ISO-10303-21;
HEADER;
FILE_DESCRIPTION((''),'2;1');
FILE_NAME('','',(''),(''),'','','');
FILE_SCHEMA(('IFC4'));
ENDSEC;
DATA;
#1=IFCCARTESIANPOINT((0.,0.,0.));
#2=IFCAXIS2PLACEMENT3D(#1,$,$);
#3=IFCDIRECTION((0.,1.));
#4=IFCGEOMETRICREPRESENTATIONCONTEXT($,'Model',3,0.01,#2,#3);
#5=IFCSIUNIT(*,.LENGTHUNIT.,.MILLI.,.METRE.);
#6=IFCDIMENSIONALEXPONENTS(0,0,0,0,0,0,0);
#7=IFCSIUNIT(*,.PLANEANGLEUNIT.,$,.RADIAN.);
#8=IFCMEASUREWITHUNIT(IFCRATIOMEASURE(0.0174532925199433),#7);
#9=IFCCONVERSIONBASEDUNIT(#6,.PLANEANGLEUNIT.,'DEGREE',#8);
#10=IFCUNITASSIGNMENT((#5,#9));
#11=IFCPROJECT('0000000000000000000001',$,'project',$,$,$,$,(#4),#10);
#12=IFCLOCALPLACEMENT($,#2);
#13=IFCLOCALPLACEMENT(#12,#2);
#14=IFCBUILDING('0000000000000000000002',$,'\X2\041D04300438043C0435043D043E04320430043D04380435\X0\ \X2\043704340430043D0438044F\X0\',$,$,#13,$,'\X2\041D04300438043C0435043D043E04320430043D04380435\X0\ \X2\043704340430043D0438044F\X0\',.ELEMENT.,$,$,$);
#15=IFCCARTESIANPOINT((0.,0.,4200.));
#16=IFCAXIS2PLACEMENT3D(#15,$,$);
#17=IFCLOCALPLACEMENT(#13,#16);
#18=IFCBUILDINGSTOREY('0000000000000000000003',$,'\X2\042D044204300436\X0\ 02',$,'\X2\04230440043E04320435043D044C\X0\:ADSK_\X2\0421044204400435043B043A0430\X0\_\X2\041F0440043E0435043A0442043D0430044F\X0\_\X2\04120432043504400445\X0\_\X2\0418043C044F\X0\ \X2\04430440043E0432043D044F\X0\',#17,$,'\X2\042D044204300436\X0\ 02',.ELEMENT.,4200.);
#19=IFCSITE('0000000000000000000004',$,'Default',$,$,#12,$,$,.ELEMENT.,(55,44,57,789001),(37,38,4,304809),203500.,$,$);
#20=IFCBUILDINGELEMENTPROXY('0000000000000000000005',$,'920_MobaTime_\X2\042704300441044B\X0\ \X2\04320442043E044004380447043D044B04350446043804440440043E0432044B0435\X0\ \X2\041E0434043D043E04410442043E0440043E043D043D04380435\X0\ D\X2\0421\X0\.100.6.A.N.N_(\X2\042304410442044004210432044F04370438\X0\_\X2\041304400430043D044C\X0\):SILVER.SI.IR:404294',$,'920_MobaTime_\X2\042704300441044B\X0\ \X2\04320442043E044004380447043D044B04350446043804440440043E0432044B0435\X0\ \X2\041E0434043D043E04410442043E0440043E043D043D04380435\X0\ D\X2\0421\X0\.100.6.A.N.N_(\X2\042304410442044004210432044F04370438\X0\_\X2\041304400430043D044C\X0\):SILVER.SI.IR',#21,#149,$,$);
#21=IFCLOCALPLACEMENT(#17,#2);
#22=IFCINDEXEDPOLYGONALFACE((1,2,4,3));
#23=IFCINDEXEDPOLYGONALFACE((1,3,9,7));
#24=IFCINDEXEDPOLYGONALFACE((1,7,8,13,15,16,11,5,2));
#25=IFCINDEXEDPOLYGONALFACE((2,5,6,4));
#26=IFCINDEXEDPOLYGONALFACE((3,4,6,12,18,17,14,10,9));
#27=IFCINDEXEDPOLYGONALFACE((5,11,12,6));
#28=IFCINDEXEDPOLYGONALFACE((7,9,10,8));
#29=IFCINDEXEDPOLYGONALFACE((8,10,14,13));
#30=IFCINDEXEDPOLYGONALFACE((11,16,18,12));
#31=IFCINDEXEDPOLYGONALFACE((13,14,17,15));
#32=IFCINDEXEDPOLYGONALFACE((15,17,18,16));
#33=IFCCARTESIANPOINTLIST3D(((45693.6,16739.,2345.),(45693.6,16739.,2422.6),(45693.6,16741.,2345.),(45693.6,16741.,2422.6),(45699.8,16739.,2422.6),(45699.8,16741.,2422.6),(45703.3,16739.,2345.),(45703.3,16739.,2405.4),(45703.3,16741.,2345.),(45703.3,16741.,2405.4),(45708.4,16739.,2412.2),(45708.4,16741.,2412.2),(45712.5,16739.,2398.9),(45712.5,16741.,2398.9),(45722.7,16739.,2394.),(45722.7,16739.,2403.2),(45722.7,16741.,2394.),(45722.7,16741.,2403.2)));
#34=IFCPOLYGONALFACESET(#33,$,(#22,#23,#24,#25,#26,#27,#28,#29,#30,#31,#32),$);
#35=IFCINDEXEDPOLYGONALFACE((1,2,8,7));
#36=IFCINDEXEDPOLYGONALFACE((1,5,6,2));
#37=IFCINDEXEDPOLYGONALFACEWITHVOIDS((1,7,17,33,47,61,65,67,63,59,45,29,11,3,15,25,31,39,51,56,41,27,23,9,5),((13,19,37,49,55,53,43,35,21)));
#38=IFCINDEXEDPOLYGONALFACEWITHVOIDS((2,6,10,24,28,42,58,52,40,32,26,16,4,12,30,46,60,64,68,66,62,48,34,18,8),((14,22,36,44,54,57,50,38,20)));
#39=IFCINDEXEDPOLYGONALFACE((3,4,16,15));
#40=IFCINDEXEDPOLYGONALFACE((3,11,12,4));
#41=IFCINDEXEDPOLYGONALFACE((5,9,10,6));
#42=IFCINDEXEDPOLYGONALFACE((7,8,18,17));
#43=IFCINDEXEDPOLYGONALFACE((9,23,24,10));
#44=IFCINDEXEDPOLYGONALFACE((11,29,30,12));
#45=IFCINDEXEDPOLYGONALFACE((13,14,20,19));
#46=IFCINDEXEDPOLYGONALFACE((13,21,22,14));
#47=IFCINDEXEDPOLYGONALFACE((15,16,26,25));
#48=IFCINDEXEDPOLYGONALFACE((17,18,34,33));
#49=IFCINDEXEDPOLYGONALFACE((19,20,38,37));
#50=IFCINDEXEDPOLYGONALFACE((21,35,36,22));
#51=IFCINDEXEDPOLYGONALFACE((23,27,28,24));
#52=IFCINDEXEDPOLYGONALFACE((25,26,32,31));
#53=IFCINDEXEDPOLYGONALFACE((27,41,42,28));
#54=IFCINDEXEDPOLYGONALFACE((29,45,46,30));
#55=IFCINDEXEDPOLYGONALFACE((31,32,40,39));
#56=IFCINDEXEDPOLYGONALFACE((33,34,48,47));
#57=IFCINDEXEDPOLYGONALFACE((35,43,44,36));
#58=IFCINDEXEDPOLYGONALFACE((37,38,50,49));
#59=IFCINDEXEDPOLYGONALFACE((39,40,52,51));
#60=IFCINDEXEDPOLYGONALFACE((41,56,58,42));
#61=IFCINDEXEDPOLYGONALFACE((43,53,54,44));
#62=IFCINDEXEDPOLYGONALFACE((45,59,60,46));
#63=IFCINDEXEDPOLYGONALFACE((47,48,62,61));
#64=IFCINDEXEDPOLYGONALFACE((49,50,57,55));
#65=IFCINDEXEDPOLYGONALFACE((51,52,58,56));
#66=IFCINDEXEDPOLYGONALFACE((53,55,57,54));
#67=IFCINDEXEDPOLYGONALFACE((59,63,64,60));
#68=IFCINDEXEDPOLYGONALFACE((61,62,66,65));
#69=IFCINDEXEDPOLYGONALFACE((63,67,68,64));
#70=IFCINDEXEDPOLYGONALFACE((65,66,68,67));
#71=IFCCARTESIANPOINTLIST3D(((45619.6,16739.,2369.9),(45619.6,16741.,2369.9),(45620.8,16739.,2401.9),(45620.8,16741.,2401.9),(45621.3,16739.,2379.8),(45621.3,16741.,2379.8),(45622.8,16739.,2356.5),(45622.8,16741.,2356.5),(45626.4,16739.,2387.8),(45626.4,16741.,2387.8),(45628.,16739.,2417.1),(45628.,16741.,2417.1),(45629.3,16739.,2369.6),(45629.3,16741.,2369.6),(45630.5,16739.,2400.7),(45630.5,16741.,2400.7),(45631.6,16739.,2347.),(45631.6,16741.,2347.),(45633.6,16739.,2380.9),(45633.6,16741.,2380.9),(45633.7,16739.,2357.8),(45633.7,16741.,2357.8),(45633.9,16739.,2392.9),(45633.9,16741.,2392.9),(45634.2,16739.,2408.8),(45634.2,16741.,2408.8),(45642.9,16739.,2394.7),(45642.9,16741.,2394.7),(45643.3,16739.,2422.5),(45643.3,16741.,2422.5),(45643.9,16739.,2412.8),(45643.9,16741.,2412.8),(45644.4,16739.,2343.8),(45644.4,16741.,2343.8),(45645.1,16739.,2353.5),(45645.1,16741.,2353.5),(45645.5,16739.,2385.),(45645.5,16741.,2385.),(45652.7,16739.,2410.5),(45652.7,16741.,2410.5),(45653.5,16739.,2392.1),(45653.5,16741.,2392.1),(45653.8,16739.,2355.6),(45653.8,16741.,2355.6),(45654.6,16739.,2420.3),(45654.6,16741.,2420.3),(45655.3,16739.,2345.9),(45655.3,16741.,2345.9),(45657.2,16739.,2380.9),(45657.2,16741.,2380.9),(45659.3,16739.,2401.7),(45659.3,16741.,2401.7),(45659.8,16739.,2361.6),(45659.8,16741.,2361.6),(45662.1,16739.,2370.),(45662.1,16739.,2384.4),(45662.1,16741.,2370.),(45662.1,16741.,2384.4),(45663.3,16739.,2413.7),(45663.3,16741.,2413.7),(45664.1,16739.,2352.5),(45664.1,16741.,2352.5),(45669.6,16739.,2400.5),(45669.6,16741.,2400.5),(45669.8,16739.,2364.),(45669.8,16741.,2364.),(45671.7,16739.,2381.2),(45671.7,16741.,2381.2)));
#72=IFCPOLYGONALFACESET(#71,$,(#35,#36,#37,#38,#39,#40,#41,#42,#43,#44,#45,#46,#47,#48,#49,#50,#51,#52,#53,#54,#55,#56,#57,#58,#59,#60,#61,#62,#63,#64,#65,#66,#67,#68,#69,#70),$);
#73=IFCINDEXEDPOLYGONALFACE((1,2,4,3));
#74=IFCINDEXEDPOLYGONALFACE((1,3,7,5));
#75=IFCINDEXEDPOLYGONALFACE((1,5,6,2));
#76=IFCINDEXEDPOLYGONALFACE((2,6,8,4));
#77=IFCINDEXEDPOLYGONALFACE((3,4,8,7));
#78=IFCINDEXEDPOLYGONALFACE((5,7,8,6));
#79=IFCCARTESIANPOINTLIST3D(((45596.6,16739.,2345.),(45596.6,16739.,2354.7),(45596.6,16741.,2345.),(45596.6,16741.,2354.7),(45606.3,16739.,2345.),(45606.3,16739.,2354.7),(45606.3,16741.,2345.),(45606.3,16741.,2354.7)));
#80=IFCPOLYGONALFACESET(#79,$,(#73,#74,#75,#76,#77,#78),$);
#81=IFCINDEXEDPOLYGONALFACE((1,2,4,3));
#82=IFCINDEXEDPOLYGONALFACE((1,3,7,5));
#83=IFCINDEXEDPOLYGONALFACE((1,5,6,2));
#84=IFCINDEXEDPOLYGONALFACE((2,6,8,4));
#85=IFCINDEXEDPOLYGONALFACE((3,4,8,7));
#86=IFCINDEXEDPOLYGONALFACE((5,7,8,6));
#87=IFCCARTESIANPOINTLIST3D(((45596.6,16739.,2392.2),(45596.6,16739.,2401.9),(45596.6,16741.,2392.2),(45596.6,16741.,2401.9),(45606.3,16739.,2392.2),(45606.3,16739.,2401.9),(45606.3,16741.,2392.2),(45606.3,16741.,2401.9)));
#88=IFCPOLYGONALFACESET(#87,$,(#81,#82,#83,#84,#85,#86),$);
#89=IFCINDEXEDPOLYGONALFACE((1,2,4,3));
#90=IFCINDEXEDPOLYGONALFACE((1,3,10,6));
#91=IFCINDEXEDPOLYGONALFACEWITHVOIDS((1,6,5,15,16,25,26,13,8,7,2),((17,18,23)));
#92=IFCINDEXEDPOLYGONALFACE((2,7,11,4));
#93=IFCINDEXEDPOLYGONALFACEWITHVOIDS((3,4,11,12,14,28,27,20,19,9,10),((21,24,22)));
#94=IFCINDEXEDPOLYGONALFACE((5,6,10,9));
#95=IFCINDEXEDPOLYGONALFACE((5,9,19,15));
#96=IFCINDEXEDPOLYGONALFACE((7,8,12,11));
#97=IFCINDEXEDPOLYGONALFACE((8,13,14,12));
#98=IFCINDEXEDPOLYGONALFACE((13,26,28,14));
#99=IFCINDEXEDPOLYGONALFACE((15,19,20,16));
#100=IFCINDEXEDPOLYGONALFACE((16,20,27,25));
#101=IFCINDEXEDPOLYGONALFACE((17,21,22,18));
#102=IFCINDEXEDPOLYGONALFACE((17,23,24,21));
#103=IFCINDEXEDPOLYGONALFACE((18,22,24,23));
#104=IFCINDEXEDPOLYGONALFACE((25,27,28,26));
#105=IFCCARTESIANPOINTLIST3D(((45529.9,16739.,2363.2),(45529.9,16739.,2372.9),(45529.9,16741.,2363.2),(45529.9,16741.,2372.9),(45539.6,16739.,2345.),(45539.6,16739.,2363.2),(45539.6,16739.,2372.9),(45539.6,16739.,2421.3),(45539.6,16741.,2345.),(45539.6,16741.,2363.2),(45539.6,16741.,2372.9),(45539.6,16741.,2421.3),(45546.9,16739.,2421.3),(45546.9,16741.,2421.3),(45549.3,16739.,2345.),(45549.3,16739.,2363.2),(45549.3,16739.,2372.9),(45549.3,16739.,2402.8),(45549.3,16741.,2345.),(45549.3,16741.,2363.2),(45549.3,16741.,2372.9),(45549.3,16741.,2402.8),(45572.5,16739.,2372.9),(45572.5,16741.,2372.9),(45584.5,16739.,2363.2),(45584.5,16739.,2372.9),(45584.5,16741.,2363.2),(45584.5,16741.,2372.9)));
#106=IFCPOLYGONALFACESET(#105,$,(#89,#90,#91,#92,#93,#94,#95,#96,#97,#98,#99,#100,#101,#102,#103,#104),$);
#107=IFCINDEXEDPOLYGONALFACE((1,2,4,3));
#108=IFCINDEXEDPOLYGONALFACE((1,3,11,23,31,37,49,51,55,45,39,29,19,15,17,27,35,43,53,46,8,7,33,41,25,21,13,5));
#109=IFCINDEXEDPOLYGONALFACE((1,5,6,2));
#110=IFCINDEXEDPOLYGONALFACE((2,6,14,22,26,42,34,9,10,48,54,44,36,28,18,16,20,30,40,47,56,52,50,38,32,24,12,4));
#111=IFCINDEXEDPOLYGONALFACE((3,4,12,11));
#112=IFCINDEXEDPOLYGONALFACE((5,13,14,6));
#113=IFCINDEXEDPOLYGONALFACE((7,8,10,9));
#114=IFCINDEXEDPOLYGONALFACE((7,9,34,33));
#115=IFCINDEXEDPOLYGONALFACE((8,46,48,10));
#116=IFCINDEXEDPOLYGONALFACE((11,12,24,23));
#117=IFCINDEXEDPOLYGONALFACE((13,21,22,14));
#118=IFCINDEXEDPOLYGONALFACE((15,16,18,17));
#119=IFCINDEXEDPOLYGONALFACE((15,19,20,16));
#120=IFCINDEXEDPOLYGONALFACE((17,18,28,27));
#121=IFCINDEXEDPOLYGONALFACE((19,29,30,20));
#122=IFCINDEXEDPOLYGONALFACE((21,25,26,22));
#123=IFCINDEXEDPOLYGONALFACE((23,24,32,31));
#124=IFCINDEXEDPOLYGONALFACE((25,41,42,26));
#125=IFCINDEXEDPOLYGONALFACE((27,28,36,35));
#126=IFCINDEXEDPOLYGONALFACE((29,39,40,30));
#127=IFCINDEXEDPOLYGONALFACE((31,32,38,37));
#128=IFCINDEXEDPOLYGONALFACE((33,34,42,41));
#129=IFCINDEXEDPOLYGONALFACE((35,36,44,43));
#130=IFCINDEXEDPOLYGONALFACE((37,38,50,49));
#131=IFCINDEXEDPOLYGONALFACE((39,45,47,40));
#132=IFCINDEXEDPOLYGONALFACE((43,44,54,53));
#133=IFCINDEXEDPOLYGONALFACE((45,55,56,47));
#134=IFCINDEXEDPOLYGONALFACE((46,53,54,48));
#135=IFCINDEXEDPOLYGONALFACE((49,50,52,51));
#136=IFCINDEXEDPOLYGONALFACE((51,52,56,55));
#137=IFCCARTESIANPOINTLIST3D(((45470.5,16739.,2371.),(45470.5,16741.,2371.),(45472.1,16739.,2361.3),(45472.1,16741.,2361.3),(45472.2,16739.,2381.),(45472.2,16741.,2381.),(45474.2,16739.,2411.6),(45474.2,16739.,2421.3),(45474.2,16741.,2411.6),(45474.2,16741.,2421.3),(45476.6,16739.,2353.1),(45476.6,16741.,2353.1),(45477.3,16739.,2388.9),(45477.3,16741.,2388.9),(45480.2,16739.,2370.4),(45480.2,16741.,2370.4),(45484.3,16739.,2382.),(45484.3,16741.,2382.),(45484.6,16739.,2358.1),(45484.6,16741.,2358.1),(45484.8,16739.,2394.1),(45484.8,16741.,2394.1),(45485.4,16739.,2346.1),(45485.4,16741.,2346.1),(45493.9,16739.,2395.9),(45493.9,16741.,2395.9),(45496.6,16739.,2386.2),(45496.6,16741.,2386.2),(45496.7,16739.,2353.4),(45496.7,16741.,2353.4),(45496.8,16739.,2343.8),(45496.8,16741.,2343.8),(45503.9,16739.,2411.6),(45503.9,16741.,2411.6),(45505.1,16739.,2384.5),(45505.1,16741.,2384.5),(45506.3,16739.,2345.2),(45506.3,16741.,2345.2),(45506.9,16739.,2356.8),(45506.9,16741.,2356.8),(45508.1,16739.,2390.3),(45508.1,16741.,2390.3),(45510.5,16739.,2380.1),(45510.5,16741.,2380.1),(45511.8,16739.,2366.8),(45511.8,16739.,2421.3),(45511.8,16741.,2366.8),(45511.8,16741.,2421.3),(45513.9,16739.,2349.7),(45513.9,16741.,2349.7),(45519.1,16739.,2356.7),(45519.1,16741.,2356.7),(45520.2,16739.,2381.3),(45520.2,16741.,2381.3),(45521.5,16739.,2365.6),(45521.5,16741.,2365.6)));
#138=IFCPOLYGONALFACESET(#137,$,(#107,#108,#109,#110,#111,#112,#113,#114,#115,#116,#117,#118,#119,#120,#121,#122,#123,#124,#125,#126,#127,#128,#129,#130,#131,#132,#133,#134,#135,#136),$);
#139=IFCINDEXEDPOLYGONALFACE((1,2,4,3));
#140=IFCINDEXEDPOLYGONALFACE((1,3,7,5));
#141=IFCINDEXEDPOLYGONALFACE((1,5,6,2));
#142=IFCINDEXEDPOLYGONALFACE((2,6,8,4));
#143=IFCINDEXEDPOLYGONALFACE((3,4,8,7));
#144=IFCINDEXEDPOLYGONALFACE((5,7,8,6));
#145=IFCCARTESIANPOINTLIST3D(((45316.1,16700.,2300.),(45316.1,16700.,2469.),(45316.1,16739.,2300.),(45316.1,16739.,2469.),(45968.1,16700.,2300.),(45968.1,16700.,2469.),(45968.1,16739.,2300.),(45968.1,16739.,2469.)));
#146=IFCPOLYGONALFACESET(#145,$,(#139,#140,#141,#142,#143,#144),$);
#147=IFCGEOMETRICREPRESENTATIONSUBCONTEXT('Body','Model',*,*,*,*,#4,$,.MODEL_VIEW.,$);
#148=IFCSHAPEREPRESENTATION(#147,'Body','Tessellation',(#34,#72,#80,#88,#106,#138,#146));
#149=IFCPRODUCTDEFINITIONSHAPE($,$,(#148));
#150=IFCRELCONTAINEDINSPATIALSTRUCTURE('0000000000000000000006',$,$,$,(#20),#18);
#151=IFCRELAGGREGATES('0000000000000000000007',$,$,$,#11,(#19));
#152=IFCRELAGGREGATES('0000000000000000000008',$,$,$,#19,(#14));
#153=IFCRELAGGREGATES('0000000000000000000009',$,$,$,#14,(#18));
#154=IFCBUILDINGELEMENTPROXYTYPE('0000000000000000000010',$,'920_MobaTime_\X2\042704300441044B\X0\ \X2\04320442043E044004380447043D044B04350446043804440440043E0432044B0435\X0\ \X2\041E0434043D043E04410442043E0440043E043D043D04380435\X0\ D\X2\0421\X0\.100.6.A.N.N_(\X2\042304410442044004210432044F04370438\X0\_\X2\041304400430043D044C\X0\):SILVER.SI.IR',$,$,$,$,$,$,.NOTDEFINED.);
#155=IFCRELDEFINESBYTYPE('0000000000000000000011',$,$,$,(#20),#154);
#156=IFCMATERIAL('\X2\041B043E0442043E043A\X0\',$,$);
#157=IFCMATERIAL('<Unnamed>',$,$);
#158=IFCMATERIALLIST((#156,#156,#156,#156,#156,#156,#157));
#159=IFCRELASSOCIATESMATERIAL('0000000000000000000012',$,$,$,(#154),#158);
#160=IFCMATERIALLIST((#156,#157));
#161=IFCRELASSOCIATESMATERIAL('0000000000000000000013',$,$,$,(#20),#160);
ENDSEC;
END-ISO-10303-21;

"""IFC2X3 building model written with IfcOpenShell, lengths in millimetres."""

from ifc_helpers import new_model, entity, si_unit, converted_unit, direction, frame, origin, origin_2d_with_axis, place, context, subcontext, project, spatial, polyline, rectangle, outline, extrude, source, transform, mapped, material, material_list, type_object, type_shapes, element, save


model = new_model("IFC2X3")

# Units and contexts
model_context = context("Model", 3, precision=0.01, world=origin(), true_north=direction((0.0, 1.0)))
body_context = subcontext(model_context, "Body", "Model", "MODEL_VIEW")
ifc_project = project(units=[si_unit("LENGTHUNIT", "METRE", prefix="MILLI"), converted_unit("PLANEANGLEUNIT", "DEGREE", entity("IfcRatioMeasure", 0.0174532925199433), si_unit("PLANEANGLEUNIT", "RADIAN"), dimensions=[0, 0, 0, 0, 0, 0, 0])], contexts=[model_context])

# Site, building, storey
site_placement = place(None, origin())
site = spatial("IfcSite", under=ifc_project, at=site_placement, Name="Default", CompositionType="ELEMENT", RefLatitude=(55, 44, 57, 789001), RefLongitude=(37, 38, 4, 304809), RefElevation=203500.0)
building_placement = place(site_placement, origin())
building = spatial("IfcBuilding", under=site, at=building_placement, Name="Наименование здания", LongName="Наименование здания", CompositionType="ELEMENT")
storey_placement = place(building_placement, frame((0.0, 0.0, 4200.0)))
storey = spatial("IfcBuildingStorey", under=building, at=storey_placement, Name="Этаж 02", ObjectType="Уровень:ADSK_Стрелка_Проектная_Вверх_Имя уровня", LongName="Этаж 02", CompositionType="ELEMENT", Elevation=4200.0)

# Building element proxy
ifc_material_1 = material(Name="Лоток")
ifc_material_2 = material(Name="<Unnamed>")
ifc_material_list_1 = material_list([ifc_material_1, ifc_material_2])
ifc_material_list_2 = material_list([ifc_material_1, ifc_material_1, ifc_material_1, ifc_material_1, ifc_material_1, ifc_material_1, ifc_material_2])
building_element_proxy_type_1 = type_object("IfcBuildingElementProxyType", Name="920_MobaTime_Часы вторичныецифровые Односторонние DС.100.6.A.N.N_(УстрСвязи_Грань):SILVER.SI.IR", PredefinedType="NOTDEFINED", material=ifc_material_list_2)
shared_shape_1 = source(origin(), body_context, "Body", "SweptSolid", [
    extrude(outline(polyline([(-49.3, -13.1), (28.2, -13.1), (28.2, -6.8), (17.9, 1.8), (8.8, 16.0), (-0.3, 16.0), (4.6, 5.8), (11.1, -3.4), (-49.3, -3.4), (-49.3, -13.1)])), frame((-64.6, 9.8, 39.0), z_axis=(0.0, 0.0, 1.0), x_axis=(0.0, 1.0, 0.0)), (0.0, 0.0, 1.0), 2.0),
    extrude(outline(polyline([(2.2, -27.6), (19.0, -27.6), (30.5, -16.1), (33.3, -4.9), (31.0, 5.8), (21.8, 17.2), (5.2, 27.3), (-11.1, 33.0), (-24.0, 32.7), (-33.6, 27.6), (-40.3, 18.6), (-42.8, 5.7), (-38.0, -6.3), (-27.2, -14.9), (-17.5, -17.7), (-8.2, -16.4), (-0.3, -11.9), (5.1, -4.5), (7.3, 6.2), (4.0, 17.2), (18.4, 7.3), (23.6, -2.4), (22.0, -11.4), (14.2, -18.4), (5.3, -18.3), (2.2, -27.6)]), holes=[polyline([(-9.0, 23.3), (-1.3, 14.3), (-2.5, 2.0), (-11.4, -7.0), (-23.4, -6.0), (-32.2, 2.9), (-31.2, 15.1), (-25.6, 22.1), (-17.5, 24.9), (-9.0, 23.3)])]), frame((-2.7, 3.6, 39.0), z_axis=(0.0, 0.0, 1.0), x_axis=(-0.427649, 0.903945, 0.0)), (0.0, 0.0, 1.0), 2.0),
    extrude(rectangle(XDim=9.7, YDim=9.7, at=origin_2d_with_axis()), frame((40.6, -34.7, 39.0)), (0.0, 0.0, 1.0), 2.0),
    extrude(rectangle(XDim=9.7, YDim=9.7, at=origin_2d_with_axis()), frame((40.6, 12.6, 39.0)), (0.0, 0.0, 1.0), 2.0),
    extrude(outline(polyline([(-0.9, -28.1), (8.8, -28.1), (8.8, -9.9), (18.5, -9.9), (18.5, -0.2), (8.8, -0.2), (8.8, 48.3), (1.5, 48.3), (-36.0, -0.2), (-36.0, -9.9), (-0.9, -9.9), (-0.9, -28.1)]), holes=[polyline([(-0.9, -0.2), (-24.1, -0.2), (-0.9, 29.7), (-0.9, -0.2)])]), frame((93.6, -11.4, 39.0)), (0.0, 0.0, 1.0), 2.0),
    extrude(outline(polyline([(3.3, -28.3), (12.5, -28.3), (20.5, -25.0), (26.8, -18.9), (30.7, -10.0), (31.4, 1.6), (26.9, 11.8), (20.1, 18.4), (11.1, 22.3), (1.0, 23.3), (-7.9, 20.4), (-14.9, 14.5), (-18.9, 6.2), (-17.1, -9.0), (-36.7, 0.5), (-29.1, 29.2), (-38.5, 31.7), (-48.1, -4.6), (-11.6, -23.1), (-8.0, -14.0), (-10.8, -7.6), (-10.2, 1.1), (-3.0, 11.8), (9.2, 12.8), (20.0, 5.5), (21.4, -7.5), (15.5, -16.4), (4.6, -18.6), (3.3, -28.3)])), frame((147.1, -8.5, 39.0), z_axis=(0.0, 0.0, 1.0), x_axis=(0.256974, -0.966418, 0.0)), (0.0, 0.0, 1.0), 2.0),
    extrude(rectangle(XDim=652.0, YDim=169.0, at=origin_2d_with_axis()), frame((0.0, 0.0, 0.0), z_axis=(0.0, 0.0, 1.0), x_axis=(-1.0, 0.0, 0.0)), (0.0, 0.0, 1.0), 39.0),
])
type_shapes(building_element_proxy_type_1, [shared_shape_1])
for number, where, z_axis, x_axis, name in (
    (1, (45642.1, 16700.0, 2384.5), (0.0, 1.0, 0.0), (-1.0, 0.0, 0.0), "920_MobaTime_Часы вторичныецифровые Односторонние DС.100.6.A.N.N_(УстрСвязи_Грань):SILVER.SI.IR:404294"),
):
    element("IfcBuildingElementProxy", number, at=place(storey_placement, frame(where, z_axis=z_axis, x_axis=x_axis)), inside=storey, type_object=building_element_proxy_type_1, material=ifc_material_list_1, Name=name, ObjectType="920_MobaTime_Часы вторичныецифровые Односторонние DС.100.6.A.N.N_(УстрСвязи_Грань):SILVER.SI.IR", context=body_context, shape_type="MappedRepresentation", body=[
        mapped(shared_shape_1, transform((0.0, 0.0, 0.0), scale=1.0)),
    ])

save(model, "model.ifc")
